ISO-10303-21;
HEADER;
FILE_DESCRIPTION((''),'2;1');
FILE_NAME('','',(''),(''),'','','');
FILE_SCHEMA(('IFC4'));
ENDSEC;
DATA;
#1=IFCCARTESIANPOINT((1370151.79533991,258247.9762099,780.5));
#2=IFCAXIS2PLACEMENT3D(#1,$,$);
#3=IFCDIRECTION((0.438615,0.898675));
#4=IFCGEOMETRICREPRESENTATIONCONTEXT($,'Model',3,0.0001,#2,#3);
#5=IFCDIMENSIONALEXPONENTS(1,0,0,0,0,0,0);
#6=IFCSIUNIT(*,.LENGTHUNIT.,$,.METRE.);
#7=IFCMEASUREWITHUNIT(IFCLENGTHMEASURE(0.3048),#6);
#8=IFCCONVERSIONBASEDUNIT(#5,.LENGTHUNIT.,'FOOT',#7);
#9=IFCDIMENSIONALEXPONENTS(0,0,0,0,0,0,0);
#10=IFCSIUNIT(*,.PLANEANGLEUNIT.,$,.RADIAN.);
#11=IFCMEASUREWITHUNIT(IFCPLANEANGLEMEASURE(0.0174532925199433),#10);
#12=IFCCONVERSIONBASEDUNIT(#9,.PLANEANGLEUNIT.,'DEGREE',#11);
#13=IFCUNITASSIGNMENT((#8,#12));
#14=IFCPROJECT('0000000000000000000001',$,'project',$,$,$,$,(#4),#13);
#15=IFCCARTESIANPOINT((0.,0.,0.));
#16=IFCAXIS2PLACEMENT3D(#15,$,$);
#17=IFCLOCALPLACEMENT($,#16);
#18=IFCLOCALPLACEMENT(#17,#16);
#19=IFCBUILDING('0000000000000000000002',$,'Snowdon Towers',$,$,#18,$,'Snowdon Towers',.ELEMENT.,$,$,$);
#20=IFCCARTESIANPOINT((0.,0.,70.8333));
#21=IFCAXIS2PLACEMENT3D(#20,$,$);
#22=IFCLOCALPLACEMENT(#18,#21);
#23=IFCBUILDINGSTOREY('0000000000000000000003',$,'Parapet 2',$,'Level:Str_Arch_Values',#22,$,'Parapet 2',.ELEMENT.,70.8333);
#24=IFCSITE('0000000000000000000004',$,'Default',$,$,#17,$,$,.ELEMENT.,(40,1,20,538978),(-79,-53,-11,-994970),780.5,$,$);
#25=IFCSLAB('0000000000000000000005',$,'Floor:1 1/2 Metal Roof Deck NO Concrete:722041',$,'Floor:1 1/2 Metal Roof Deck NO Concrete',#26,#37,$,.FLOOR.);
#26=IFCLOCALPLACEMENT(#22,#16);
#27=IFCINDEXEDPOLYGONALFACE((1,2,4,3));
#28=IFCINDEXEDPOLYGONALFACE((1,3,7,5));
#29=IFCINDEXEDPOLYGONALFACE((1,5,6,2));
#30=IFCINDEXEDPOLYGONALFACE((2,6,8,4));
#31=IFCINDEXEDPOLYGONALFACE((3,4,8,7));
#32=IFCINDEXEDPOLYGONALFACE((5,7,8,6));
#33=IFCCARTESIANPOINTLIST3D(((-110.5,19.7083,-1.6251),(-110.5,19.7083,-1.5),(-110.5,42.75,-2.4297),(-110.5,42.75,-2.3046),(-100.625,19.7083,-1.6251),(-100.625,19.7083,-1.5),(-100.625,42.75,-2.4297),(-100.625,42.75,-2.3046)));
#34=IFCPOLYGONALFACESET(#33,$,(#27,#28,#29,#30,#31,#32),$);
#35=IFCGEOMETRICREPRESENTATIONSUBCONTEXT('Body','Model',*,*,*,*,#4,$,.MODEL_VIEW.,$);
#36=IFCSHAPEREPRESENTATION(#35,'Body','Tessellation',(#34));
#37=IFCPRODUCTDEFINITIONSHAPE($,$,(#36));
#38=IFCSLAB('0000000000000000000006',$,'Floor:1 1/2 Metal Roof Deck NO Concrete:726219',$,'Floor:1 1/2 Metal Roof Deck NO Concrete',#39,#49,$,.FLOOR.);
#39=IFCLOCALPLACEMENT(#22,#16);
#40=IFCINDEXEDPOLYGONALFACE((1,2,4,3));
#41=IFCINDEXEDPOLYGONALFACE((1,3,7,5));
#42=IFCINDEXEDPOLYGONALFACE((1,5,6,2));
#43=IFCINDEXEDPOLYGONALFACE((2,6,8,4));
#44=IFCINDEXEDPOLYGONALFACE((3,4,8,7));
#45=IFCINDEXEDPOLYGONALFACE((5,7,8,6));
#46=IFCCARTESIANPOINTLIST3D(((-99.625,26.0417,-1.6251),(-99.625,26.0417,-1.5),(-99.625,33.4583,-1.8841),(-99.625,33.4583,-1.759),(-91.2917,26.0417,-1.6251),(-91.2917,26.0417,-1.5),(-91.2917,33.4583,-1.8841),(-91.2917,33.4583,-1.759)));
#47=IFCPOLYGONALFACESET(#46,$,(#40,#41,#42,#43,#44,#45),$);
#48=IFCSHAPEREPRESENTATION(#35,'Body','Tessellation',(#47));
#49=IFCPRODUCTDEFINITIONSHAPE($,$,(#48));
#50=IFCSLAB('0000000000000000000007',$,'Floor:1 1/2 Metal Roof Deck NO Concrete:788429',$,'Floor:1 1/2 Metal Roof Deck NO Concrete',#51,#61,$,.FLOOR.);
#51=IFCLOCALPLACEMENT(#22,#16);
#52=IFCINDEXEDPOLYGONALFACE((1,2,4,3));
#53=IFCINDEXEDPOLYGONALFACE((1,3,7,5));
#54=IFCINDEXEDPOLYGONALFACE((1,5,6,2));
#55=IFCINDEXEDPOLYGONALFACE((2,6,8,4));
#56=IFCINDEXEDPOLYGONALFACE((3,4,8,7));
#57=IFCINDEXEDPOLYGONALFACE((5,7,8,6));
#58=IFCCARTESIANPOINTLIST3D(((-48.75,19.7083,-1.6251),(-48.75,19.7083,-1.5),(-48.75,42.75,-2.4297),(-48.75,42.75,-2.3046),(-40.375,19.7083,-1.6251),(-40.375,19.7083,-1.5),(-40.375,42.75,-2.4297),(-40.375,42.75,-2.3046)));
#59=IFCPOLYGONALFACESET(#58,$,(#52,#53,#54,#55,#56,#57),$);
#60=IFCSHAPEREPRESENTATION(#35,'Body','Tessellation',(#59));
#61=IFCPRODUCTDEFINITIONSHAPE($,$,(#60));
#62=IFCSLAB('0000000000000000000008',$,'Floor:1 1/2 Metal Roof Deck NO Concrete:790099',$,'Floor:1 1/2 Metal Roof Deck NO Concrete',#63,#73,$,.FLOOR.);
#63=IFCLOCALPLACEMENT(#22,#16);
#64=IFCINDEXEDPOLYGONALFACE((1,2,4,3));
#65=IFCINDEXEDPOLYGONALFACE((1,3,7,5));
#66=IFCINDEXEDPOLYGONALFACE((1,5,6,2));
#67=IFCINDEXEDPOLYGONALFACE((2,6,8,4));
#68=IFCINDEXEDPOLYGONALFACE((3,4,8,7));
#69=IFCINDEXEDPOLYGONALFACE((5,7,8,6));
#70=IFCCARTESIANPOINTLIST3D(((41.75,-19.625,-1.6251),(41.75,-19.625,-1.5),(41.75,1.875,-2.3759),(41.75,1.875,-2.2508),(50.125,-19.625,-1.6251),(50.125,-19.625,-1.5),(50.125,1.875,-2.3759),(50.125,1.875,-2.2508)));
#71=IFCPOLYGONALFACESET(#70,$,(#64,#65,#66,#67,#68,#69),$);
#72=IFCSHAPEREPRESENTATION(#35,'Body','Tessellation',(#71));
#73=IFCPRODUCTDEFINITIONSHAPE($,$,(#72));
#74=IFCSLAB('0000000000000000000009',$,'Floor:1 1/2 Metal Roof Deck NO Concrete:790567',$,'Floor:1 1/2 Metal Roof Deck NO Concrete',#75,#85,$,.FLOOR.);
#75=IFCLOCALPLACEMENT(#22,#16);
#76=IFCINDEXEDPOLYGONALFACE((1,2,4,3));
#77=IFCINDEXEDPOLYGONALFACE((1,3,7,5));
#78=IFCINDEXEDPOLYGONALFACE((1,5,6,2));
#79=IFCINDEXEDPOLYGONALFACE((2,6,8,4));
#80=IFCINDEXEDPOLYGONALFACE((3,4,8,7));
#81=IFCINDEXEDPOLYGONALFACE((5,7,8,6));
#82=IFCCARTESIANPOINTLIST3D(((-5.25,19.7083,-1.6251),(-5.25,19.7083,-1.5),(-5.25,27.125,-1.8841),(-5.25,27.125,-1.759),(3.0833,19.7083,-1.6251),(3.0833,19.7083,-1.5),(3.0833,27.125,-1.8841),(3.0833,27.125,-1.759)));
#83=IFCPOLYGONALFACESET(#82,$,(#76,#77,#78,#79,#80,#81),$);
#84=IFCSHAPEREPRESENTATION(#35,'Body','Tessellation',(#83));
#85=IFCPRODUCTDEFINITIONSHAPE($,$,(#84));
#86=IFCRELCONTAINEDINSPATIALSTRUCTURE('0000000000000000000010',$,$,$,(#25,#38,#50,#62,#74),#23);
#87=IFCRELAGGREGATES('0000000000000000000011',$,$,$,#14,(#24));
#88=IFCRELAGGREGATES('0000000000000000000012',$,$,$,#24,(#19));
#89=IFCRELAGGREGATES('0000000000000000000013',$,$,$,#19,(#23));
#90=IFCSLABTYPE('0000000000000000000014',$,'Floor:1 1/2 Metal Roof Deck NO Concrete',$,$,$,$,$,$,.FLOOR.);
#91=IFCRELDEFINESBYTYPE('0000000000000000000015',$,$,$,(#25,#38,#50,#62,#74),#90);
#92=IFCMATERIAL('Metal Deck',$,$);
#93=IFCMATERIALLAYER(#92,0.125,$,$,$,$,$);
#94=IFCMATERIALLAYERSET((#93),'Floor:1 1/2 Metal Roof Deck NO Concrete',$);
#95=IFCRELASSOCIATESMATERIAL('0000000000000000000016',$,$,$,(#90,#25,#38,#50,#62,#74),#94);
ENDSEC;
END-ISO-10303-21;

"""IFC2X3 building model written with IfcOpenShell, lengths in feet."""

from ifc_helpers import new_model, entity, si_unit, converted_unit, direction, frame, frame_2d, origin, place, context, subcontext, project, spatial, rectangle, extrude, clip, halfspace, material, layer, layer_set, layer_usage, type_object, element, save


model = new_model("IFC2X3")

# Units and contexts
model_context = context("Model", 3, precision=0.0001, world=frame((1370151.79533991, 258247.9762099, 780.5)), true_north=direction((0.438615, 0.898675)))
body_context = subcontext(model_context, "Body", "Model", "MODEL_VIEW")
ifc_project = project(units=[converted_unit("LENGTHUNIT", "FOOT", entity("IfcLengthMeasure", 0.3048), si_unit("LENGTHUNIT", "METRE"), dimensions=[1, 0, 0, 0, 0, 0, 0]), converted_unit("PLANEANGLEUNIT", "DEGREE", entity("IfcPlaneAngleMeasure", 0.0174532925199433), si_unit("PLANEANGLEUNIT", "RADIAN"), dimensions=[0, 0, 0, 0, 0, 0, 0])], contexts=[model_context])

# Site, building, storey
site_placement = place(None, origin())
site = spatial("IfcSite", under=ifc_project, at=site_placement, Name="Default", CompositionType="ELEMENT", RefLatitude=(40, 1, 20, 538978), RefLongitude=(-79, -53, -11, -994970), RefElevation=780.5)
building_placement = place(site_placement, origin())
building = spatial("IfcBuilding", under=site, at=building_placement, Name="Snowdon Towers", LongName="Snowdon Towers", CompositionType="ELEMENT")
storey_placement = place(building_placement, frame((0.0, 0.0, 70.8333)))
storey = spatial("IfcBuildingStorey", under=building, at=storey_placement, Name="Parapet 2", ObjectType="Level:Str_Arch_Values", LongName="Parapet 2", CompositionType="ELEMENT", Elevation=70.8333)

# Slabs
ifc_material_1 = material(Name="Metal Deck")
ifc_layer = layer(ifc_material_1, 0.125)
ifc_layer_set = layer_set([ifc_layer], Name="Floor:1 1/2 Metal Roof Deck NO Concrete")
ifc_layer_usage_1 = layer_usage(ifc_layer_set, "AXIS3", "POSITIVE", 0.0)
slab_type = type_object("IfcSlabType", Name="Floor:1 1/2 Metal Roof Deck NO Concrete", PredefinedType="FLOOR", material=ifc_layer_set)
slab_1_placement = place(storey_placement, origin())
element("IfcSlab", 1, at=slab_1_placement, inside=storey, type_object=slab_type, material=ifc_layer_usage_1, Name="Floor:1 1/2 Metal Roof Deck NO Concrete:722041", ObjectType="Floor:1 1/2 Metal Roof Deck NO Concrete", PredefinedType="FLOOR", context=body_context, shape_type="SweptSolid", body=[
    clip(clip(extrude(rectangle(XDim=23.0557, YDim=9.875, at=frame_2d((0.0, 0.0), x_axis=(1.0, 0.0))), frame((-105.5625, 31.2292, -1.9023), z_axis=(0.0, -0.034899, -0.999391), x_axis=(0.0, 0.999391, -0.034899)), (0.034899, 0.0, 0.999391), 0.1252), halfspace(frame((-100.625, 19.7083, -1.6251), z_axis=(0.0, -0.034899, -0.999391), x_axis=(0.0, -0.999391, 0.034899)), False)), halfspace(frame((-100.625, 19.7083, -1.5), z_axis=(0.0, 0.034899, 0.999391), x_axis=(0.0, 0.999391, -0.034899)), False)),
])
ifc_layer_usage_2 = layer_usage(ifc_layer_set, "AXIS3", "POSITIVE", 0.0)
slab_2_placement = place(storey_placement, origin())
element("IfcSlab", 2, at=slab_2_placement, inside=storey, type_object=slab_type, material=ifc_layer_usage_2, Name="Floor:1 1/2 Metal Roof Deck NO Concrete:726219", ObjectType="Floor:1 1/2 Metal Roof Deck NO Concrete", PredefinedType="FLOOR", context=body_context, shape_type="SweptSolid", body=[
    clip(clip(extrude(rectangle(XDim=7.4212, YDim=8.3333, at=frame_2d((0.0, 0.0), x_axis=(1.0, 0.0))), frame((-95.4583, 29.75, -1.6295), z_axis=(0.0, -0.034899, -0.999391), x_axis=(0.0, 0.999391, -0.034899)), (0.034899, 0.0, 0.999391), 0.1252), halfspace(frame((-91.2917, 26.0417, -1.6251), z_axis=(0.0, -0.034899, -0.999391), x_axis=(0.0, -0.999391, 0.034899)), False)), halfspace(frame((-91.2917, 26.0417, -1.5), z_axis=(0.0, 0.034899, 0.999391), x_axis=(0.0, 0.999391, -0.034899)), False)),
])
ifc_layer_usage_3 = layer_usage(ifc_layer_set, "AXIS3", "POSITIVE", 0.0)
slab_3_placement = place(storey_placement, origin())
element("IfcSlab", 3, at=slab_3_placement, inside=storey, type_object=slab_type, material=ifc_layer_usage_3, Name="Floor:1 1/2 Metal Roof Deck NO Concrete:788429", ObjectType="Floor:1 1/2 Metal Roof Deck NO Concrete", PredefinedType="FLOOR", context=body_context, shape_type="SweptSolid", body=[
    clip(clip(extrude(rectangle(XDim=23.0557, YDim=8.375, at=frame_2d((0.0, 0.0), x_axis=(1.0, 0.0))), frame((-44.5625, 31.2292, -1.9023), z_axis=(0.0, -0.034899, -0.999391), x_axis=(0.0, 0.999391, -0.034899)), (0.034899, 0.0, 0.999391), 0.1252), halfspace(frame((-40.375, 19.7083, -1.6251), z_axis=(0.0, -0.034899, -0.999391), x_axis=(0.0, -0.999391, 0.034899)), False)), halfspace(frame((-40.375, 19.7083, -1.5), z_axis=(0.0, 0.034899, 0.999391), x_axis=(0.0, 0.999391, -0.034899)), False)),
])
ifc_layer_usage_4 = layer_usage(ifc_layer_set, "AXIS3", "POSITIVE", 0.0)
slab_4_placement = place(storey_placement, origin())
element("IfcSlab", 4, at=slab_4_placement, inside=storey, type_object=slab_type, material=ifc_layer_usage_4, Name="Floor:1 1/2 Metal Roof Deck NO Concrete:790099", ObjectType="Floor:1 1/2 Metal Roof Deck NO Concrete", PredefinedType="FLOOR", context=body_context, shape_type="SweptSolid", body=[
    clip(clip(extrude(rectangle(XDim=21.5131, YDim=8.375, at=frame_2d((0.0, 0.0), x_axis=(1.0, 0.0))), frame((45.9375, -8.875, -1.8754), z_axis=(0.0, -0.034899, -0.999391), x_axis=(0.0, 0.999391, -0.034899)), (0.034899, 0.0, 0.999391), 0.1252), halfspace(frame((50.125, -19.625, -1.6251), z_axis=(0.0, -0.034899, -0.999391), x_axis=(0.0, -0.999391, 0.034899)), False)), halfspace(frame((50.125, -19.625, -1.5), z_axis=(0.0, 0.034899, 0.999391), x_axis=(0.0, 0.999391, -0.034899)), False)),
])
ifc_layer_usage_5 = layer_usage(ifc_layer_set, "AXIS3", "POSITIVE", 0.0)
slab_5_placement = place(storey_placement, origin())
element("IfcSlab", 5, at=slab_5_placement, inside=storey, type_object=slab_type, material=ifc_layer_usage_5, Name="Floor:1 1/2 Metal Roof Deck NO Concrete:790567", ObjectType="Floor:1 1/2 Metal Roof Deck NO Concrete", PredefinedType="FLOOR", context=body_context, shape_type="SweptSolid", body=[
    clip(clip(extrude(rectangle(XDim=7.4212, YDim=8.3333, at=frame_2d((0.0, 0.0), x_axis=(1.0, 0.0))), frame((-1.0833, 23.4167, -1.6295), z_axis=(0.0, -0.034899, -0.999391), x_axis=(0.0, 0.999391, -0.034899)), (0.034899, 0.0, 0.999391), 0.1252), halfspace(frame((3.0833, 19.7083, -1.6251), z_axis=(0.0, -0.034899, -0.999391), x_axis=(0.0, -0.999391, 0.034899)), False)), halfspace(frame((3.0833, 19.7083, -1.5), z_axis=(0.0, 0.034899, 0.999391), x_axis=(0.0, 0.999391, -0.034899)), False)),
])

save(model, "model.ifc")
